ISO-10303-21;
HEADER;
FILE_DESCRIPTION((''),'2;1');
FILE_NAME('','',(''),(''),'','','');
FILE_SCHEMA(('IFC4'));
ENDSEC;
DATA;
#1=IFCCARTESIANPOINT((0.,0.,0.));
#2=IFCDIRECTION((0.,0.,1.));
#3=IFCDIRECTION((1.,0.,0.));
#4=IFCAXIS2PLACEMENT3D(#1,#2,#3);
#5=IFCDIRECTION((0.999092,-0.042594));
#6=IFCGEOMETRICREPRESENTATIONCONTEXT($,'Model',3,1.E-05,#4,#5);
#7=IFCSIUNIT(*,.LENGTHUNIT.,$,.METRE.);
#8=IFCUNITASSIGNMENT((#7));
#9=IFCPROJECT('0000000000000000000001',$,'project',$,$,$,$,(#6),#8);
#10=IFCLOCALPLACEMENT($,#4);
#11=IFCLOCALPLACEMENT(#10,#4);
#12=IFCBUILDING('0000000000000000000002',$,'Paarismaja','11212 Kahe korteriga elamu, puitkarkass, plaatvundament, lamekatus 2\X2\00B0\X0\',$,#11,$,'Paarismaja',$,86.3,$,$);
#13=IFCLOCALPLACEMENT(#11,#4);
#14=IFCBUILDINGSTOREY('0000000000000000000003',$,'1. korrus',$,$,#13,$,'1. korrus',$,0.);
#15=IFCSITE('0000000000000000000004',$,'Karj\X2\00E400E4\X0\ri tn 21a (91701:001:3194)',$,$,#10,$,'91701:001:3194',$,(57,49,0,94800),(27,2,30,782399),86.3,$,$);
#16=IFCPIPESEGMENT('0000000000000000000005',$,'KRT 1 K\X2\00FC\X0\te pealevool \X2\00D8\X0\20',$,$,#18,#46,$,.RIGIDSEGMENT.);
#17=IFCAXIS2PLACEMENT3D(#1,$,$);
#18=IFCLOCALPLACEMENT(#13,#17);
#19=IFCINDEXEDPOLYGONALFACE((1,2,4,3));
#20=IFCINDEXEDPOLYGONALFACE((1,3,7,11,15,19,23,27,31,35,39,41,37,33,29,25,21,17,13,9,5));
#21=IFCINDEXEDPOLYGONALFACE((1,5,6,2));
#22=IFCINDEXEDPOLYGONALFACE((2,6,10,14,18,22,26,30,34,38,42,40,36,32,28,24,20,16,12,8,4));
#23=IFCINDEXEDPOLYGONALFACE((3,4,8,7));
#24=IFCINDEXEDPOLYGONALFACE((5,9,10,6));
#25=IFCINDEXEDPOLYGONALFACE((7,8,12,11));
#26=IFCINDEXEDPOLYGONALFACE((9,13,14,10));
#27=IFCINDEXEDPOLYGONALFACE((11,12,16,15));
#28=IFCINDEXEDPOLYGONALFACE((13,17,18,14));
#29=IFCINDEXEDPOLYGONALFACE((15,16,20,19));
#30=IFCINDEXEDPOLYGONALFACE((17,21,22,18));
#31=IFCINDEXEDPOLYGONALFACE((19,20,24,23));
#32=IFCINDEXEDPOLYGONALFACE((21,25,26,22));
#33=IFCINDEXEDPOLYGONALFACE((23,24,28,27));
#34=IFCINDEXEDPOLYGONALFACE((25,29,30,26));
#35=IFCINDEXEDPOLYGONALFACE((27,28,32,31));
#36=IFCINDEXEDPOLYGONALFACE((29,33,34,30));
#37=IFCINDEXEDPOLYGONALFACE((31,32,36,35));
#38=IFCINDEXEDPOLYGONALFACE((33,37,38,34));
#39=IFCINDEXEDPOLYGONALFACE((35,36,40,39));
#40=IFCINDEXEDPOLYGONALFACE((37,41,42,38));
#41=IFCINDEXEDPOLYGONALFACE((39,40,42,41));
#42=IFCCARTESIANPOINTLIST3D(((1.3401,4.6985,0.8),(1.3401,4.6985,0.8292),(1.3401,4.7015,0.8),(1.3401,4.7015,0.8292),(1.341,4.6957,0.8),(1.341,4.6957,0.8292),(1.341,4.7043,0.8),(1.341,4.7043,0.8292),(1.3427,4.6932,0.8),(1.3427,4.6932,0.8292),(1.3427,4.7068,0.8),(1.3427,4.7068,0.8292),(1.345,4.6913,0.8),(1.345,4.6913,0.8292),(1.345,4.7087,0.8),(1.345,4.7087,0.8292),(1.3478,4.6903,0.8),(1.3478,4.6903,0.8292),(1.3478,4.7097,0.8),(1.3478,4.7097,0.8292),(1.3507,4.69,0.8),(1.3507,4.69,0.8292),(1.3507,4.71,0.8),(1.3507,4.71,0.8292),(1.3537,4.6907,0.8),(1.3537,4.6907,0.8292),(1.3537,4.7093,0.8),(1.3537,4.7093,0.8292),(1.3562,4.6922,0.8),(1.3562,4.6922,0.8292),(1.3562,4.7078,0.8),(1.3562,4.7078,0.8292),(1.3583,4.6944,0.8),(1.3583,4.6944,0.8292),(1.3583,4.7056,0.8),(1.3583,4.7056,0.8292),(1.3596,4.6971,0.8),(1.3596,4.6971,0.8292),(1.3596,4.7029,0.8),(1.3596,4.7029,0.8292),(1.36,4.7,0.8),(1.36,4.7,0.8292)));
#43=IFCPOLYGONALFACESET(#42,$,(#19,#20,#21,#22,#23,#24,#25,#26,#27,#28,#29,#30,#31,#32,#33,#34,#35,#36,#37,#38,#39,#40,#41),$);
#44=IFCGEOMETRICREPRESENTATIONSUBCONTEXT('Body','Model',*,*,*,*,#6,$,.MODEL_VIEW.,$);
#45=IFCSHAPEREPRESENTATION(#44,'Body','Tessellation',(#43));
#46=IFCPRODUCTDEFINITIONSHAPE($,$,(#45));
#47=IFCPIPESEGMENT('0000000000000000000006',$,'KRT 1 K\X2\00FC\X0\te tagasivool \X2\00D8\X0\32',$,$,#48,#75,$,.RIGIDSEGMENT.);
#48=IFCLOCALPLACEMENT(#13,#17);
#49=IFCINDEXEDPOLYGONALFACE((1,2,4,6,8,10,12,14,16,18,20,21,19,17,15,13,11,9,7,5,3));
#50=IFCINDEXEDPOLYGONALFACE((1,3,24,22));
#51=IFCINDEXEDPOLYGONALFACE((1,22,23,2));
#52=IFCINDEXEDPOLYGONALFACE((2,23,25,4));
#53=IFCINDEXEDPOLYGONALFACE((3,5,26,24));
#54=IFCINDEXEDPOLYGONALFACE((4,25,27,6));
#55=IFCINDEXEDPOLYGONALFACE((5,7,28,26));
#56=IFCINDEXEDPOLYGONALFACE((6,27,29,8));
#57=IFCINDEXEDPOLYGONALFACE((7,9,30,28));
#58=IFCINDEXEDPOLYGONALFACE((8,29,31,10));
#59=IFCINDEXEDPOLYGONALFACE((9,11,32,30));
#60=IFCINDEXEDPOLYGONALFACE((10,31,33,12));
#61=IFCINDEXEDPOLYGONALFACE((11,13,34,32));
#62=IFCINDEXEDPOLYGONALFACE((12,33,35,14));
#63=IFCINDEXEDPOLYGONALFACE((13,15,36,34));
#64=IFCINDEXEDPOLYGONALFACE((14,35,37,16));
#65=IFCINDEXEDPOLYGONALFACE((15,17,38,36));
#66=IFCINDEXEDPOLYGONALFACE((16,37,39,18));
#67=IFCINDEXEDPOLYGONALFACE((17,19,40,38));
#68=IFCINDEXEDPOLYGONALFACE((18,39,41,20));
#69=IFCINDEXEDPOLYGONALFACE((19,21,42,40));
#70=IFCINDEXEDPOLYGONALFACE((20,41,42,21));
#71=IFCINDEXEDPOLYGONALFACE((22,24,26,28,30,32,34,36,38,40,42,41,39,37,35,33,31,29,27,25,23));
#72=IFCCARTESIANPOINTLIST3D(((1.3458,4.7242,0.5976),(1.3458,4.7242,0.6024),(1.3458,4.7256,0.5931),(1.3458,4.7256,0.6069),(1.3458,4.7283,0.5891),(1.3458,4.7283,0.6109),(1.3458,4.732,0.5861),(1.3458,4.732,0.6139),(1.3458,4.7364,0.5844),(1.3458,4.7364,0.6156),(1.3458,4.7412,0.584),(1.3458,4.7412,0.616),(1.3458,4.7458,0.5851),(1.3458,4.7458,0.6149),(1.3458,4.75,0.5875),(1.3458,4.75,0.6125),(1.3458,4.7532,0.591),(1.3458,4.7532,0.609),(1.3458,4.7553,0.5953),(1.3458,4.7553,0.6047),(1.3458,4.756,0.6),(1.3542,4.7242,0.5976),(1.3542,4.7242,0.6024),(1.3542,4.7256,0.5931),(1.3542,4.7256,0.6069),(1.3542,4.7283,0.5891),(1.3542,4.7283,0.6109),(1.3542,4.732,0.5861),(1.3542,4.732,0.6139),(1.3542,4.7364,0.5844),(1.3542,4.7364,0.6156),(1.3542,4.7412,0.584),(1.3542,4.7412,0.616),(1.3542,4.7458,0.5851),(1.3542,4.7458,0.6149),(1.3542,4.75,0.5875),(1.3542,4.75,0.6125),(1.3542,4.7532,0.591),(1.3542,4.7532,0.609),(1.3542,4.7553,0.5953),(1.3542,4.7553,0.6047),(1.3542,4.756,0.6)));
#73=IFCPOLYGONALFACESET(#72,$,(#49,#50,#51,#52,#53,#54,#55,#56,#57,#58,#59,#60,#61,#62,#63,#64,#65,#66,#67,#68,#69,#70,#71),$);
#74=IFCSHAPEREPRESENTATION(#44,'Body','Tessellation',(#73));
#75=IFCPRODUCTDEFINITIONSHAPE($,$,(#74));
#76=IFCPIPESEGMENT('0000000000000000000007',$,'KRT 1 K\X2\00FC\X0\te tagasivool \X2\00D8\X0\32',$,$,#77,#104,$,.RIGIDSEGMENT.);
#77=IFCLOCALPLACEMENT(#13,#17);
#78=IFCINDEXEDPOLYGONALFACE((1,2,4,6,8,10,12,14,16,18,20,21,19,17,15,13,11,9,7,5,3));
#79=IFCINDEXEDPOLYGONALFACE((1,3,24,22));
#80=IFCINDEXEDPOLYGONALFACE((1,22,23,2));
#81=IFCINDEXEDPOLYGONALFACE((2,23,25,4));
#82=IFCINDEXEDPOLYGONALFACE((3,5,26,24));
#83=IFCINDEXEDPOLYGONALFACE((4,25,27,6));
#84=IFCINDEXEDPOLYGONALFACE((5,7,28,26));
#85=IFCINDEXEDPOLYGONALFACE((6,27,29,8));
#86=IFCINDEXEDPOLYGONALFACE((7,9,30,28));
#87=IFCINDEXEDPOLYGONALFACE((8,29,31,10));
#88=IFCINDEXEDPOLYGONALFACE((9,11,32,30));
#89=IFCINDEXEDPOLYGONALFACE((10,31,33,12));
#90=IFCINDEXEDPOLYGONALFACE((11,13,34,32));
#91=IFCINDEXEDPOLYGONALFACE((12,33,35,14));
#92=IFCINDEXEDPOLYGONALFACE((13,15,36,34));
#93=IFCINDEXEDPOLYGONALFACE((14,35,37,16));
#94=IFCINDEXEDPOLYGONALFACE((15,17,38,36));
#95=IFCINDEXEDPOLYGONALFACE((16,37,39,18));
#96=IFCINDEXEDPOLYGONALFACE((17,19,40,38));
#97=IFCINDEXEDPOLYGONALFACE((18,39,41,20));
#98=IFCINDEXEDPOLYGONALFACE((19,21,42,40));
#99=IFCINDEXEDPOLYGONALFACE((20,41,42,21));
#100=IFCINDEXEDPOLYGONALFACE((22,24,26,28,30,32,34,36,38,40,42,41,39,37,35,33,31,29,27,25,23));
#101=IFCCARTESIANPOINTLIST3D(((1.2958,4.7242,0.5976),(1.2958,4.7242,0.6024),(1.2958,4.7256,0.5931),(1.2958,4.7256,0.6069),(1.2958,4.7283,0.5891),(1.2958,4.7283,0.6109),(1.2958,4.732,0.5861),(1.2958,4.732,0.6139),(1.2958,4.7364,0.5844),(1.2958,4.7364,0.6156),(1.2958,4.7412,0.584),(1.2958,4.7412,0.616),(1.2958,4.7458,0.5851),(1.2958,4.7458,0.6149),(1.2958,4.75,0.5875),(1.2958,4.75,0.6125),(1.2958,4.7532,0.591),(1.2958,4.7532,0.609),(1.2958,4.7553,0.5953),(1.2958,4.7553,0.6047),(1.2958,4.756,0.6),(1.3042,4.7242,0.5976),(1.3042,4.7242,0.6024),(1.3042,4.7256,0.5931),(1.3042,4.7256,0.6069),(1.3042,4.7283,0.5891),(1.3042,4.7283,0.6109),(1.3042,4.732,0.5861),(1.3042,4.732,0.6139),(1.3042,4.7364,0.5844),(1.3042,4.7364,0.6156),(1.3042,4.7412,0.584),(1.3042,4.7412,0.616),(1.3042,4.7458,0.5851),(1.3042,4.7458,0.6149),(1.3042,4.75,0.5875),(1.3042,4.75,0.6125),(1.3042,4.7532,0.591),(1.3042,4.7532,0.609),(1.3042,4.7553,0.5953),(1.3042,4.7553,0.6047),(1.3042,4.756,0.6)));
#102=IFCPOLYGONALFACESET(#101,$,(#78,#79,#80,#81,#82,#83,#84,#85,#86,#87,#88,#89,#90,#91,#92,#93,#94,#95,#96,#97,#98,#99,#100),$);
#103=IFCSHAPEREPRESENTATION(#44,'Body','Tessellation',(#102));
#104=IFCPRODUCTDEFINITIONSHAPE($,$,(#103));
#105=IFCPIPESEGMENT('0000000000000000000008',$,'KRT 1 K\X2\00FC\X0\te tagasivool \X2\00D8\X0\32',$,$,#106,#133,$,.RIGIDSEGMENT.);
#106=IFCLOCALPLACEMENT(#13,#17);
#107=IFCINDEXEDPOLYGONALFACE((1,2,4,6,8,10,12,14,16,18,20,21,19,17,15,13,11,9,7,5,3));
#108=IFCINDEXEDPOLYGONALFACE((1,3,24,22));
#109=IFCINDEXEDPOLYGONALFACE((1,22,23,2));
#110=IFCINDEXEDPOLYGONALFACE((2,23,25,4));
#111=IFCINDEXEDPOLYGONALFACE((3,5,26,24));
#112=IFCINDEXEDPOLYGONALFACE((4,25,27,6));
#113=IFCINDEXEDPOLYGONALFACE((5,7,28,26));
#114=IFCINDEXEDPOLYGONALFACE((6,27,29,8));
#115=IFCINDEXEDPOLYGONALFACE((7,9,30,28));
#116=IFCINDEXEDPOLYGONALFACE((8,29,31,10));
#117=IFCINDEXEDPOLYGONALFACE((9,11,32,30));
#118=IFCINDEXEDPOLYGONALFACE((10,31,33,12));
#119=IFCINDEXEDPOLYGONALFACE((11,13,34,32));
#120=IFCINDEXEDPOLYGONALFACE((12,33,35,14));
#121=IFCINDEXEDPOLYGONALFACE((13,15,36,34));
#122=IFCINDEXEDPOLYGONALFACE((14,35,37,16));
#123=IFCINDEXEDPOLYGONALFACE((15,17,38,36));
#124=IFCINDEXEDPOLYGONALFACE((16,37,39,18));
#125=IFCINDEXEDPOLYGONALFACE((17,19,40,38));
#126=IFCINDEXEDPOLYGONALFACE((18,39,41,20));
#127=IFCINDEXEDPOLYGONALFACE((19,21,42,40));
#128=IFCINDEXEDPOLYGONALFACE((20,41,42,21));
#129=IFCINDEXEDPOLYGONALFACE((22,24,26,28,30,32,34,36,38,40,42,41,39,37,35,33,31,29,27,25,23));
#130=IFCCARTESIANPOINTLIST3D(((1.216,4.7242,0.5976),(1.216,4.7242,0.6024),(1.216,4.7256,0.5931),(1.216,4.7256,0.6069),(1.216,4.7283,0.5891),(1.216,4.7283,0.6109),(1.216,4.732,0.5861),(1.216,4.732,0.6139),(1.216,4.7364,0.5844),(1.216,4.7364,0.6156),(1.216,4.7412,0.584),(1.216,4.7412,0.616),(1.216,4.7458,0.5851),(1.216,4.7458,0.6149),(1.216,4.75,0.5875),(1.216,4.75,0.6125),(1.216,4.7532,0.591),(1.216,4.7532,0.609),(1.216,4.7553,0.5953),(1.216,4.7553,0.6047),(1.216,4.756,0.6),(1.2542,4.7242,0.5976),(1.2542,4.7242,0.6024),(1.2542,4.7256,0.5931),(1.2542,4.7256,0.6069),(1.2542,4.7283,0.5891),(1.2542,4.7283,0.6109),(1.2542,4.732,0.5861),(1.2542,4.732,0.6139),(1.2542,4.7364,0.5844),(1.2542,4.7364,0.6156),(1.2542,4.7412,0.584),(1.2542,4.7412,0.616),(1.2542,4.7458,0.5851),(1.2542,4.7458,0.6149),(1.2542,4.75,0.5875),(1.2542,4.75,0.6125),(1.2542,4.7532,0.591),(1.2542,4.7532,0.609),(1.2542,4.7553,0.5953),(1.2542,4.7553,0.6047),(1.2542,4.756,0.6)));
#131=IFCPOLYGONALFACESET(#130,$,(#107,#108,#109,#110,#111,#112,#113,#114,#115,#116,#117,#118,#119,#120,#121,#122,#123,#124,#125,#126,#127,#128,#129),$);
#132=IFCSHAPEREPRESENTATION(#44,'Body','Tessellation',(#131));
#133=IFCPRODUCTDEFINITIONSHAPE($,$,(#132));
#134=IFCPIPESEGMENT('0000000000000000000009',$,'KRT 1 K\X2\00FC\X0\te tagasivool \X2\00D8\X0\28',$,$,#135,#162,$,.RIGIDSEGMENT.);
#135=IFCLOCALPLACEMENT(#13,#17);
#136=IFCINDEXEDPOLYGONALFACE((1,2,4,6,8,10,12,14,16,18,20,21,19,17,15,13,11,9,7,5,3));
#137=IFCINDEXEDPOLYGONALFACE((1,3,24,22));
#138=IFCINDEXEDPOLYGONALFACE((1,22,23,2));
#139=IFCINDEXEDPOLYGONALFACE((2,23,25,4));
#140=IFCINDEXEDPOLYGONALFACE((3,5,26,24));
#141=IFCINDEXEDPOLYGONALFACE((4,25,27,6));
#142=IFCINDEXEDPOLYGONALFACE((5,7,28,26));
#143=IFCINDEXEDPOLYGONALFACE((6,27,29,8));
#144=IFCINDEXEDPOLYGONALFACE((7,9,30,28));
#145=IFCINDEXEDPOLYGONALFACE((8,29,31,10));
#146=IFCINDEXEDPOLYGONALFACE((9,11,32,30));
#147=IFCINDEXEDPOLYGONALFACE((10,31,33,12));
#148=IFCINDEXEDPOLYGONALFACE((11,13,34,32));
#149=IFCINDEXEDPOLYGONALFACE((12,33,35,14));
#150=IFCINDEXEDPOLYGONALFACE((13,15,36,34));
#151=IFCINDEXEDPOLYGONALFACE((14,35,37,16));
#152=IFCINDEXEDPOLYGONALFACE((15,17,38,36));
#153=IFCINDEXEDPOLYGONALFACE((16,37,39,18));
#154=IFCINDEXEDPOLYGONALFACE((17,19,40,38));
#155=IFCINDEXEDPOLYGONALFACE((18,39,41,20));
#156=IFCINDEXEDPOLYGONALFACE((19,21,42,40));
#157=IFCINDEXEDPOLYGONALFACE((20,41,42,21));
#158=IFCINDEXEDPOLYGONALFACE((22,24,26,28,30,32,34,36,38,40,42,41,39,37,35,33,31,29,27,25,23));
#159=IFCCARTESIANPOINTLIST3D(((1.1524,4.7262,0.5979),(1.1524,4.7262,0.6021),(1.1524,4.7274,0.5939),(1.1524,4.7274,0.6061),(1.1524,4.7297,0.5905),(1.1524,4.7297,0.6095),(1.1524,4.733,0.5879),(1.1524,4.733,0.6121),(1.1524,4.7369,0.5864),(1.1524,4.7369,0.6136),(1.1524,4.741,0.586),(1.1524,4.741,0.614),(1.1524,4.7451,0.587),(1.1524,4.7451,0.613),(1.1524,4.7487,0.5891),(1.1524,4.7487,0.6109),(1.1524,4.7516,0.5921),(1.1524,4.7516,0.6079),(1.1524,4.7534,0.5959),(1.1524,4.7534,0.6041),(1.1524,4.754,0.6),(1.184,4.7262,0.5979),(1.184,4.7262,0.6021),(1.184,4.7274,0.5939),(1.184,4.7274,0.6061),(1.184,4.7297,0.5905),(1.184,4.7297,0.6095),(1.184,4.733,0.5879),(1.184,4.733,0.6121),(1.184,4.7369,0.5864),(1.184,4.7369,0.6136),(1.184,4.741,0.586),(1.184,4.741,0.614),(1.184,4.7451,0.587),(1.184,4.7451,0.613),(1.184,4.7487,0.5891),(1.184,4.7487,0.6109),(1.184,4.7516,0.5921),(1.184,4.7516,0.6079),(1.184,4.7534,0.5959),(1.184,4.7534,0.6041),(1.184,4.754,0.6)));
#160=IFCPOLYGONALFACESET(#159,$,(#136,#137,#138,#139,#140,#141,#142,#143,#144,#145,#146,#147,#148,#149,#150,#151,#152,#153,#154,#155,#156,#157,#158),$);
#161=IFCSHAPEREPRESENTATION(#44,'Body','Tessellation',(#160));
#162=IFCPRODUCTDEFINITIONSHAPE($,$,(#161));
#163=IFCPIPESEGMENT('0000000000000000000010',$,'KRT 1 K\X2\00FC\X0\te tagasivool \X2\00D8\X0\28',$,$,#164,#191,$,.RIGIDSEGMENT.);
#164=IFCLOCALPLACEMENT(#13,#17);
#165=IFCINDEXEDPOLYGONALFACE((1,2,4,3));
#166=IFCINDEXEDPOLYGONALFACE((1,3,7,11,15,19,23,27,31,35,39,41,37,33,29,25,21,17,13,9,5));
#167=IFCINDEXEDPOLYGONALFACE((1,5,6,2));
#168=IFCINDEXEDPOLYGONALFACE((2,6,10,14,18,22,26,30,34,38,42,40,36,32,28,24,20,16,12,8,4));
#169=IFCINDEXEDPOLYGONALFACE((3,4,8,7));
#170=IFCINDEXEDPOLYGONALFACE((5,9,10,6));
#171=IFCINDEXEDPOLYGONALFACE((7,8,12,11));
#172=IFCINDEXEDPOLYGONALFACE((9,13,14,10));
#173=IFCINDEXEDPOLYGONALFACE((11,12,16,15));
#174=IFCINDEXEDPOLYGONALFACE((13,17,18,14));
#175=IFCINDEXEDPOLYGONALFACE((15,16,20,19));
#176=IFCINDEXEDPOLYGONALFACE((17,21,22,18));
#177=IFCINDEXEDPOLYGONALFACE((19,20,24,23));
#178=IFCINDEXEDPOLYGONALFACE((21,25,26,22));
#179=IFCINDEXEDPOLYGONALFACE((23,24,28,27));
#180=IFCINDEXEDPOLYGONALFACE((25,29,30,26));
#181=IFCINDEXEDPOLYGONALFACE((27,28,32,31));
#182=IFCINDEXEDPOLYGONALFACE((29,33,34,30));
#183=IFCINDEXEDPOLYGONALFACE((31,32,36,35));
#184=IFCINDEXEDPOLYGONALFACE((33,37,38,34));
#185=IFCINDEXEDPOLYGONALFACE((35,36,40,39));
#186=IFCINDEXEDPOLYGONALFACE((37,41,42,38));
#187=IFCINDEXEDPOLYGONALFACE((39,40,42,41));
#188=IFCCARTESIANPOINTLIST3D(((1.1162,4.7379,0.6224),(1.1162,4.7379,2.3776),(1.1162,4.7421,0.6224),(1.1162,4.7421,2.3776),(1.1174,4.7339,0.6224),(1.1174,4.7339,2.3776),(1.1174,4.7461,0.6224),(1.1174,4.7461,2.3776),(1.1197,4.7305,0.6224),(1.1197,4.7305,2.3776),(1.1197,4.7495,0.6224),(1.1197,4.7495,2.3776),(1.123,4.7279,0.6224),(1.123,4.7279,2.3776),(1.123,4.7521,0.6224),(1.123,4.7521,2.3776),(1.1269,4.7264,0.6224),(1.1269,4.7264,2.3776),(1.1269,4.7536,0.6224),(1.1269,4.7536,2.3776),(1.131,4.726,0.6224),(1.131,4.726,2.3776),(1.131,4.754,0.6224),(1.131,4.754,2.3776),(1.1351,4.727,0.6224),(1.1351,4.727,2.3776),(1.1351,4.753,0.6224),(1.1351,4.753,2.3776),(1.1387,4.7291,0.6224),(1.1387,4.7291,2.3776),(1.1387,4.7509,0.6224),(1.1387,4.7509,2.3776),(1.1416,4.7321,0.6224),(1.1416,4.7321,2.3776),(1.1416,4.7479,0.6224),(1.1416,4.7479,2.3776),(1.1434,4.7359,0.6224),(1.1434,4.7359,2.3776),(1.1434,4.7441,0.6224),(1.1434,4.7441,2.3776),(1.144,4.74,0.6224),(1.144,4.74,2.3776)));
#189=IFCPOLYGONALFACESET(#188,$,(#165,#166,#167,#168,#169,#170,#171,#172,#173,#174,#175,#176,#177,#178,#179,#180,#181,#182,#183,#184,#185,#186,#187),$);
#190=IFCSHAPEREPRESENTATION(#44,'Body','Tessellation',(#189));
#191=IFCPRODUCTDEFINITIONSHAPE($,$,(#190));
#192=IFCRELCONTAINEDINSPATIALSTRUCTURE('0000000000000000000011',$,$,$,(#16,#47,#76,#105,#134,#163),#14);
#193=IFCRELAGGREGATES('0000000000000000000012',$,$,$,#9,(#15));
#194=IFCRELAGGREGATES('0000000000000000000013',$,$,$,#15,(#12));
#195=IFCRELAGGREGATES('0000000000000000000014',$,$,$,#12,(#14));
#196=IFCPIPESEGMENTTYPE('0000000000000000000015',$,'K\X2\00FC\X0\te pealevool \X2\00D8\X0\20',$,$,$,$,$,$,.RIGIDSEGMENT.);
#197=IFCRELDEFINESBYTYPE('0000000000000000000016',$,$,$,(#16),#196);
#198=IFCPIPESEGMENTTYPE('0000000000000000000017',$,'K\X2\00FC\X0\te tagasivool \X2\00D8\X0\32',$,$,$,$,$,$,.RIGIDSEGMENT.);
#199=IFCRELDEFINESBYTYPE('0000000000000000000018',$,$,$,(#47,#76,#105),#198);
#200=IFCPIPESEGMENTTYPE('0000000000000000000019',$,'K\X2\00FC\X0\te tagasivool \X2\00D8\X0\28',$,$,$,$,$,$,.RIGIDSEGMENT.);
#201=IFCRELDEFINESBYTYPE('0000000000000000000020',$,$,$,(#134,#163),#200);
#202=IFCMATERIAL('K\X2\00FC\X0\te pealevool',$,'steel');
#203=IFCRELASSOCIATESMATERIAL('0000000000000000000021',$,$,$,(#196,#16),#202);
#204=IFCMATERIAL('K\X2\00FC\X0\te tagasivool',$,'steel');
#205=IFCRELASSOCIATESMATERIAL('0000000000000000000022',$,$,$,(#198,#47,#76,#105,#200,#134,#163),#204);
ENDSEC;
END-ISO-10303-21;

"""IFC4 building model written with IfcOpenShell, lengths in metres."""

from ifc_helpers import new_model, si_unit, direction, frame, origin_with_axes, place, context, subcontext, project, spatial, circle, extrude, material, type_object, element, save


model = new_model("IFC4")

# Units and contexts
model_context = context("Model", 3, precision=1e-05, world=origin_with_axes(), true_north=direction((0.999092, -0.042594)))
body_context = subcontext(model_context, "Body", "Model", "MODEL_VIEW")
ifc_project = project(units=[si_unit("LENGTHUNIT", "METRE")], contexts=[model_context])

# Site, building, storey
site_placement = place(None, origin_with_axes())
site = spatial("IfcSite", under=ifc_project, at=site_placement, Name="Karjääri tn 21a (91701:001:3194)", LongName="91701:001:3194", RefLatitude=(57, 49, 0, 94800), RefLongitude=(27, 2, 30, 782399), RefElevation=86.3)
building_placement = place(site_placement, origin_with_axes())
building = spatial("IfcBuilding", under=site, at=building_placement, Name="Paarismaja", Description="11212 Kahe korteriga elamu, puitkarkass, plaatvundament, lamekatus 2°", LongName="Paarismaja", ElevationOfRefHeight=86.3)
storey_placement = place(building_placement, origin_with_axes())
storey = spatial("IfcBuildingStorey", under=building, at=storey_placement, Name="1. korrus", LongName="1. korrus", Elevation=0.0)

# Shared definitions
ifc_material_1 = material(Name="Küte pealevool", Category="steel")
ifc_material_2 = material(Name="Küte tagasivool", Category="steel")

# Pipe segments
pipe_segment_type_1 = type_object("IfcPipeSegmentType", Name="Küte pealevool Ø20", PredefinedType="RIGIDSEGMENT", material=ifc_material_1)
for number, where, z_axis, x_axis, name in (
    (1, (1.35, 4.7, 0.8292), (0.0, 0.0, -1.0), (1.0, 0.0, 0.0), "KRT 1 Küte pealevool Ø20"),
):
    element("IfcPipeSegment", number, at=place(storey_placement, frame(where, z_axis=z_axis, x_axis=x_axis)), inside=storey, type_object=pipe_segment_type_1, material=ifc_material_1, Name=name, PredefinedType="RIGIDSEGMENT", context=body_context, shape_type="SweptSolid", body=[
        extrude(circle(Radius=0.01), origin_with_axes(), (0.0, 0.0, 1.0), 0.0292),
    ])
pipe_segment_type_2 = type_object("IfcPipeSegmentType", Name="Küte tagasivool Ø32", PredefinedType="RIGIDSEGMENT", material=ifc_material_2)
pipe_segment_1_placement = place(storey_placement, frame((1.3542, 4.74, 0.6), z_axis=(-1.0, 0.0, 0.0), x_axis=(0.0, 1.0, 0.0)))
element("IfcPipeSegment", 2, at=pipe_segment_1_placement, inside=storey, type_object=pipe_segment_type_2, material=ifc_material_2, Name="KRT 1 Küte tagasivool Ø32", PredefinedType="RIGIDSEGMENT", context=body_context, shape_type="SweptSolid", body=[
    extrude(circle(Radius=0.016), origin_with_axes(), (0.0, 0.0, 1.0), 0.0084),
])
pipe_segment_2_placement = place(storey_placement, frame((1.3042, 4.74, 0.6), z_axis=(-1.0, 0.0, 0.0), x_axis=(0.0, 1.0, 0.0)))
element("IfcPipeSegment", 3, at=pipe_segment_2_placement, inside=storey, type_object=pipe_segment_type_2, material=ifc_material_2, Name="KRT 1 Küte tagasivool Ø32", PredefinedType="RIGIDSEGMENT", context=body_context, shape_type="SweptSolid", body=[
    extrude(circle(Radius=0.016), origin_with_axes(), (0.0, 0.0, 1.0), 0.0084),
])
pipe_segment_3_placement = place(storey_placement, frame((1.2542, 4.74, 0.6), z_axis=(-1.0, 0.0, 0.0), x_axis=(0.0, 1.0, 0.0)))
element("IfcPipeSegment", 4, at=pipe_segment_3_placement, inside=storey, type_object=pipe_segment_type_2, material=ifc_material_2, Name="KRT 1 Küte tagasivool Ø32", PredefinedType="RIGIDSEGMENT", context=body_context, shape_type="SweptSolid", body=[
    extrude(circle(Radius=0.016), origin_with_axes(), (0.0, 0.0, 1.0), 0.0382),
])
pipe_segment_type_3 = type_object("IfcPipeSegmentType", Name="Küte tagasivool Ø28", PredefinedType="RIGIDSEGMENT", material=ifc_material_2)
pipe_segment_4_placement = place(storey_placement, frame((1.184, 4.74, 0.6), z_axis=(-1.0, 0.0, 0.0), x_axis=(0.0, 1.0, 0.0)))
element("IfcPipeSegment", 5, at=pipe_segment_4_placement, inside=storey, type_object=pipe_segment_type_3, material=ifc_material_2, Name="KRT 1 Küte tagasivool Ø28", PredefinedType="RIGIDSEGMENT", context=body_context, shape_type="SweptSolid", body=[
    extrude(circle(Radius=0.014), origin_with_axes(), (0.0, 0.0, 1.0), 0.0316),
])
pipe_segment_5_placement = place(storey_placement, frame((1.13, 4.74, 0.6224), z_axis=(0.0, 0.0, 1.0), x_axis=(1.0, 0.0, 0.0)))
element("IfcPipeSegment", 6, at=pipe_segment_5_placement, inside=storey, type_object=pipe_segment_type_3, material=ifc_material_2, Name="KRT 1 Küte tagasivool Ø28", PredefinedType="RIGIDSEGMENT", context=body_context, shape_type="SweptSolid", body=[
    extrude(circle(Radius=0.014), origin_with_axes(), (0.0, 0.0, 1.0), 1.7552),
])

save(model, "model.ifc")
